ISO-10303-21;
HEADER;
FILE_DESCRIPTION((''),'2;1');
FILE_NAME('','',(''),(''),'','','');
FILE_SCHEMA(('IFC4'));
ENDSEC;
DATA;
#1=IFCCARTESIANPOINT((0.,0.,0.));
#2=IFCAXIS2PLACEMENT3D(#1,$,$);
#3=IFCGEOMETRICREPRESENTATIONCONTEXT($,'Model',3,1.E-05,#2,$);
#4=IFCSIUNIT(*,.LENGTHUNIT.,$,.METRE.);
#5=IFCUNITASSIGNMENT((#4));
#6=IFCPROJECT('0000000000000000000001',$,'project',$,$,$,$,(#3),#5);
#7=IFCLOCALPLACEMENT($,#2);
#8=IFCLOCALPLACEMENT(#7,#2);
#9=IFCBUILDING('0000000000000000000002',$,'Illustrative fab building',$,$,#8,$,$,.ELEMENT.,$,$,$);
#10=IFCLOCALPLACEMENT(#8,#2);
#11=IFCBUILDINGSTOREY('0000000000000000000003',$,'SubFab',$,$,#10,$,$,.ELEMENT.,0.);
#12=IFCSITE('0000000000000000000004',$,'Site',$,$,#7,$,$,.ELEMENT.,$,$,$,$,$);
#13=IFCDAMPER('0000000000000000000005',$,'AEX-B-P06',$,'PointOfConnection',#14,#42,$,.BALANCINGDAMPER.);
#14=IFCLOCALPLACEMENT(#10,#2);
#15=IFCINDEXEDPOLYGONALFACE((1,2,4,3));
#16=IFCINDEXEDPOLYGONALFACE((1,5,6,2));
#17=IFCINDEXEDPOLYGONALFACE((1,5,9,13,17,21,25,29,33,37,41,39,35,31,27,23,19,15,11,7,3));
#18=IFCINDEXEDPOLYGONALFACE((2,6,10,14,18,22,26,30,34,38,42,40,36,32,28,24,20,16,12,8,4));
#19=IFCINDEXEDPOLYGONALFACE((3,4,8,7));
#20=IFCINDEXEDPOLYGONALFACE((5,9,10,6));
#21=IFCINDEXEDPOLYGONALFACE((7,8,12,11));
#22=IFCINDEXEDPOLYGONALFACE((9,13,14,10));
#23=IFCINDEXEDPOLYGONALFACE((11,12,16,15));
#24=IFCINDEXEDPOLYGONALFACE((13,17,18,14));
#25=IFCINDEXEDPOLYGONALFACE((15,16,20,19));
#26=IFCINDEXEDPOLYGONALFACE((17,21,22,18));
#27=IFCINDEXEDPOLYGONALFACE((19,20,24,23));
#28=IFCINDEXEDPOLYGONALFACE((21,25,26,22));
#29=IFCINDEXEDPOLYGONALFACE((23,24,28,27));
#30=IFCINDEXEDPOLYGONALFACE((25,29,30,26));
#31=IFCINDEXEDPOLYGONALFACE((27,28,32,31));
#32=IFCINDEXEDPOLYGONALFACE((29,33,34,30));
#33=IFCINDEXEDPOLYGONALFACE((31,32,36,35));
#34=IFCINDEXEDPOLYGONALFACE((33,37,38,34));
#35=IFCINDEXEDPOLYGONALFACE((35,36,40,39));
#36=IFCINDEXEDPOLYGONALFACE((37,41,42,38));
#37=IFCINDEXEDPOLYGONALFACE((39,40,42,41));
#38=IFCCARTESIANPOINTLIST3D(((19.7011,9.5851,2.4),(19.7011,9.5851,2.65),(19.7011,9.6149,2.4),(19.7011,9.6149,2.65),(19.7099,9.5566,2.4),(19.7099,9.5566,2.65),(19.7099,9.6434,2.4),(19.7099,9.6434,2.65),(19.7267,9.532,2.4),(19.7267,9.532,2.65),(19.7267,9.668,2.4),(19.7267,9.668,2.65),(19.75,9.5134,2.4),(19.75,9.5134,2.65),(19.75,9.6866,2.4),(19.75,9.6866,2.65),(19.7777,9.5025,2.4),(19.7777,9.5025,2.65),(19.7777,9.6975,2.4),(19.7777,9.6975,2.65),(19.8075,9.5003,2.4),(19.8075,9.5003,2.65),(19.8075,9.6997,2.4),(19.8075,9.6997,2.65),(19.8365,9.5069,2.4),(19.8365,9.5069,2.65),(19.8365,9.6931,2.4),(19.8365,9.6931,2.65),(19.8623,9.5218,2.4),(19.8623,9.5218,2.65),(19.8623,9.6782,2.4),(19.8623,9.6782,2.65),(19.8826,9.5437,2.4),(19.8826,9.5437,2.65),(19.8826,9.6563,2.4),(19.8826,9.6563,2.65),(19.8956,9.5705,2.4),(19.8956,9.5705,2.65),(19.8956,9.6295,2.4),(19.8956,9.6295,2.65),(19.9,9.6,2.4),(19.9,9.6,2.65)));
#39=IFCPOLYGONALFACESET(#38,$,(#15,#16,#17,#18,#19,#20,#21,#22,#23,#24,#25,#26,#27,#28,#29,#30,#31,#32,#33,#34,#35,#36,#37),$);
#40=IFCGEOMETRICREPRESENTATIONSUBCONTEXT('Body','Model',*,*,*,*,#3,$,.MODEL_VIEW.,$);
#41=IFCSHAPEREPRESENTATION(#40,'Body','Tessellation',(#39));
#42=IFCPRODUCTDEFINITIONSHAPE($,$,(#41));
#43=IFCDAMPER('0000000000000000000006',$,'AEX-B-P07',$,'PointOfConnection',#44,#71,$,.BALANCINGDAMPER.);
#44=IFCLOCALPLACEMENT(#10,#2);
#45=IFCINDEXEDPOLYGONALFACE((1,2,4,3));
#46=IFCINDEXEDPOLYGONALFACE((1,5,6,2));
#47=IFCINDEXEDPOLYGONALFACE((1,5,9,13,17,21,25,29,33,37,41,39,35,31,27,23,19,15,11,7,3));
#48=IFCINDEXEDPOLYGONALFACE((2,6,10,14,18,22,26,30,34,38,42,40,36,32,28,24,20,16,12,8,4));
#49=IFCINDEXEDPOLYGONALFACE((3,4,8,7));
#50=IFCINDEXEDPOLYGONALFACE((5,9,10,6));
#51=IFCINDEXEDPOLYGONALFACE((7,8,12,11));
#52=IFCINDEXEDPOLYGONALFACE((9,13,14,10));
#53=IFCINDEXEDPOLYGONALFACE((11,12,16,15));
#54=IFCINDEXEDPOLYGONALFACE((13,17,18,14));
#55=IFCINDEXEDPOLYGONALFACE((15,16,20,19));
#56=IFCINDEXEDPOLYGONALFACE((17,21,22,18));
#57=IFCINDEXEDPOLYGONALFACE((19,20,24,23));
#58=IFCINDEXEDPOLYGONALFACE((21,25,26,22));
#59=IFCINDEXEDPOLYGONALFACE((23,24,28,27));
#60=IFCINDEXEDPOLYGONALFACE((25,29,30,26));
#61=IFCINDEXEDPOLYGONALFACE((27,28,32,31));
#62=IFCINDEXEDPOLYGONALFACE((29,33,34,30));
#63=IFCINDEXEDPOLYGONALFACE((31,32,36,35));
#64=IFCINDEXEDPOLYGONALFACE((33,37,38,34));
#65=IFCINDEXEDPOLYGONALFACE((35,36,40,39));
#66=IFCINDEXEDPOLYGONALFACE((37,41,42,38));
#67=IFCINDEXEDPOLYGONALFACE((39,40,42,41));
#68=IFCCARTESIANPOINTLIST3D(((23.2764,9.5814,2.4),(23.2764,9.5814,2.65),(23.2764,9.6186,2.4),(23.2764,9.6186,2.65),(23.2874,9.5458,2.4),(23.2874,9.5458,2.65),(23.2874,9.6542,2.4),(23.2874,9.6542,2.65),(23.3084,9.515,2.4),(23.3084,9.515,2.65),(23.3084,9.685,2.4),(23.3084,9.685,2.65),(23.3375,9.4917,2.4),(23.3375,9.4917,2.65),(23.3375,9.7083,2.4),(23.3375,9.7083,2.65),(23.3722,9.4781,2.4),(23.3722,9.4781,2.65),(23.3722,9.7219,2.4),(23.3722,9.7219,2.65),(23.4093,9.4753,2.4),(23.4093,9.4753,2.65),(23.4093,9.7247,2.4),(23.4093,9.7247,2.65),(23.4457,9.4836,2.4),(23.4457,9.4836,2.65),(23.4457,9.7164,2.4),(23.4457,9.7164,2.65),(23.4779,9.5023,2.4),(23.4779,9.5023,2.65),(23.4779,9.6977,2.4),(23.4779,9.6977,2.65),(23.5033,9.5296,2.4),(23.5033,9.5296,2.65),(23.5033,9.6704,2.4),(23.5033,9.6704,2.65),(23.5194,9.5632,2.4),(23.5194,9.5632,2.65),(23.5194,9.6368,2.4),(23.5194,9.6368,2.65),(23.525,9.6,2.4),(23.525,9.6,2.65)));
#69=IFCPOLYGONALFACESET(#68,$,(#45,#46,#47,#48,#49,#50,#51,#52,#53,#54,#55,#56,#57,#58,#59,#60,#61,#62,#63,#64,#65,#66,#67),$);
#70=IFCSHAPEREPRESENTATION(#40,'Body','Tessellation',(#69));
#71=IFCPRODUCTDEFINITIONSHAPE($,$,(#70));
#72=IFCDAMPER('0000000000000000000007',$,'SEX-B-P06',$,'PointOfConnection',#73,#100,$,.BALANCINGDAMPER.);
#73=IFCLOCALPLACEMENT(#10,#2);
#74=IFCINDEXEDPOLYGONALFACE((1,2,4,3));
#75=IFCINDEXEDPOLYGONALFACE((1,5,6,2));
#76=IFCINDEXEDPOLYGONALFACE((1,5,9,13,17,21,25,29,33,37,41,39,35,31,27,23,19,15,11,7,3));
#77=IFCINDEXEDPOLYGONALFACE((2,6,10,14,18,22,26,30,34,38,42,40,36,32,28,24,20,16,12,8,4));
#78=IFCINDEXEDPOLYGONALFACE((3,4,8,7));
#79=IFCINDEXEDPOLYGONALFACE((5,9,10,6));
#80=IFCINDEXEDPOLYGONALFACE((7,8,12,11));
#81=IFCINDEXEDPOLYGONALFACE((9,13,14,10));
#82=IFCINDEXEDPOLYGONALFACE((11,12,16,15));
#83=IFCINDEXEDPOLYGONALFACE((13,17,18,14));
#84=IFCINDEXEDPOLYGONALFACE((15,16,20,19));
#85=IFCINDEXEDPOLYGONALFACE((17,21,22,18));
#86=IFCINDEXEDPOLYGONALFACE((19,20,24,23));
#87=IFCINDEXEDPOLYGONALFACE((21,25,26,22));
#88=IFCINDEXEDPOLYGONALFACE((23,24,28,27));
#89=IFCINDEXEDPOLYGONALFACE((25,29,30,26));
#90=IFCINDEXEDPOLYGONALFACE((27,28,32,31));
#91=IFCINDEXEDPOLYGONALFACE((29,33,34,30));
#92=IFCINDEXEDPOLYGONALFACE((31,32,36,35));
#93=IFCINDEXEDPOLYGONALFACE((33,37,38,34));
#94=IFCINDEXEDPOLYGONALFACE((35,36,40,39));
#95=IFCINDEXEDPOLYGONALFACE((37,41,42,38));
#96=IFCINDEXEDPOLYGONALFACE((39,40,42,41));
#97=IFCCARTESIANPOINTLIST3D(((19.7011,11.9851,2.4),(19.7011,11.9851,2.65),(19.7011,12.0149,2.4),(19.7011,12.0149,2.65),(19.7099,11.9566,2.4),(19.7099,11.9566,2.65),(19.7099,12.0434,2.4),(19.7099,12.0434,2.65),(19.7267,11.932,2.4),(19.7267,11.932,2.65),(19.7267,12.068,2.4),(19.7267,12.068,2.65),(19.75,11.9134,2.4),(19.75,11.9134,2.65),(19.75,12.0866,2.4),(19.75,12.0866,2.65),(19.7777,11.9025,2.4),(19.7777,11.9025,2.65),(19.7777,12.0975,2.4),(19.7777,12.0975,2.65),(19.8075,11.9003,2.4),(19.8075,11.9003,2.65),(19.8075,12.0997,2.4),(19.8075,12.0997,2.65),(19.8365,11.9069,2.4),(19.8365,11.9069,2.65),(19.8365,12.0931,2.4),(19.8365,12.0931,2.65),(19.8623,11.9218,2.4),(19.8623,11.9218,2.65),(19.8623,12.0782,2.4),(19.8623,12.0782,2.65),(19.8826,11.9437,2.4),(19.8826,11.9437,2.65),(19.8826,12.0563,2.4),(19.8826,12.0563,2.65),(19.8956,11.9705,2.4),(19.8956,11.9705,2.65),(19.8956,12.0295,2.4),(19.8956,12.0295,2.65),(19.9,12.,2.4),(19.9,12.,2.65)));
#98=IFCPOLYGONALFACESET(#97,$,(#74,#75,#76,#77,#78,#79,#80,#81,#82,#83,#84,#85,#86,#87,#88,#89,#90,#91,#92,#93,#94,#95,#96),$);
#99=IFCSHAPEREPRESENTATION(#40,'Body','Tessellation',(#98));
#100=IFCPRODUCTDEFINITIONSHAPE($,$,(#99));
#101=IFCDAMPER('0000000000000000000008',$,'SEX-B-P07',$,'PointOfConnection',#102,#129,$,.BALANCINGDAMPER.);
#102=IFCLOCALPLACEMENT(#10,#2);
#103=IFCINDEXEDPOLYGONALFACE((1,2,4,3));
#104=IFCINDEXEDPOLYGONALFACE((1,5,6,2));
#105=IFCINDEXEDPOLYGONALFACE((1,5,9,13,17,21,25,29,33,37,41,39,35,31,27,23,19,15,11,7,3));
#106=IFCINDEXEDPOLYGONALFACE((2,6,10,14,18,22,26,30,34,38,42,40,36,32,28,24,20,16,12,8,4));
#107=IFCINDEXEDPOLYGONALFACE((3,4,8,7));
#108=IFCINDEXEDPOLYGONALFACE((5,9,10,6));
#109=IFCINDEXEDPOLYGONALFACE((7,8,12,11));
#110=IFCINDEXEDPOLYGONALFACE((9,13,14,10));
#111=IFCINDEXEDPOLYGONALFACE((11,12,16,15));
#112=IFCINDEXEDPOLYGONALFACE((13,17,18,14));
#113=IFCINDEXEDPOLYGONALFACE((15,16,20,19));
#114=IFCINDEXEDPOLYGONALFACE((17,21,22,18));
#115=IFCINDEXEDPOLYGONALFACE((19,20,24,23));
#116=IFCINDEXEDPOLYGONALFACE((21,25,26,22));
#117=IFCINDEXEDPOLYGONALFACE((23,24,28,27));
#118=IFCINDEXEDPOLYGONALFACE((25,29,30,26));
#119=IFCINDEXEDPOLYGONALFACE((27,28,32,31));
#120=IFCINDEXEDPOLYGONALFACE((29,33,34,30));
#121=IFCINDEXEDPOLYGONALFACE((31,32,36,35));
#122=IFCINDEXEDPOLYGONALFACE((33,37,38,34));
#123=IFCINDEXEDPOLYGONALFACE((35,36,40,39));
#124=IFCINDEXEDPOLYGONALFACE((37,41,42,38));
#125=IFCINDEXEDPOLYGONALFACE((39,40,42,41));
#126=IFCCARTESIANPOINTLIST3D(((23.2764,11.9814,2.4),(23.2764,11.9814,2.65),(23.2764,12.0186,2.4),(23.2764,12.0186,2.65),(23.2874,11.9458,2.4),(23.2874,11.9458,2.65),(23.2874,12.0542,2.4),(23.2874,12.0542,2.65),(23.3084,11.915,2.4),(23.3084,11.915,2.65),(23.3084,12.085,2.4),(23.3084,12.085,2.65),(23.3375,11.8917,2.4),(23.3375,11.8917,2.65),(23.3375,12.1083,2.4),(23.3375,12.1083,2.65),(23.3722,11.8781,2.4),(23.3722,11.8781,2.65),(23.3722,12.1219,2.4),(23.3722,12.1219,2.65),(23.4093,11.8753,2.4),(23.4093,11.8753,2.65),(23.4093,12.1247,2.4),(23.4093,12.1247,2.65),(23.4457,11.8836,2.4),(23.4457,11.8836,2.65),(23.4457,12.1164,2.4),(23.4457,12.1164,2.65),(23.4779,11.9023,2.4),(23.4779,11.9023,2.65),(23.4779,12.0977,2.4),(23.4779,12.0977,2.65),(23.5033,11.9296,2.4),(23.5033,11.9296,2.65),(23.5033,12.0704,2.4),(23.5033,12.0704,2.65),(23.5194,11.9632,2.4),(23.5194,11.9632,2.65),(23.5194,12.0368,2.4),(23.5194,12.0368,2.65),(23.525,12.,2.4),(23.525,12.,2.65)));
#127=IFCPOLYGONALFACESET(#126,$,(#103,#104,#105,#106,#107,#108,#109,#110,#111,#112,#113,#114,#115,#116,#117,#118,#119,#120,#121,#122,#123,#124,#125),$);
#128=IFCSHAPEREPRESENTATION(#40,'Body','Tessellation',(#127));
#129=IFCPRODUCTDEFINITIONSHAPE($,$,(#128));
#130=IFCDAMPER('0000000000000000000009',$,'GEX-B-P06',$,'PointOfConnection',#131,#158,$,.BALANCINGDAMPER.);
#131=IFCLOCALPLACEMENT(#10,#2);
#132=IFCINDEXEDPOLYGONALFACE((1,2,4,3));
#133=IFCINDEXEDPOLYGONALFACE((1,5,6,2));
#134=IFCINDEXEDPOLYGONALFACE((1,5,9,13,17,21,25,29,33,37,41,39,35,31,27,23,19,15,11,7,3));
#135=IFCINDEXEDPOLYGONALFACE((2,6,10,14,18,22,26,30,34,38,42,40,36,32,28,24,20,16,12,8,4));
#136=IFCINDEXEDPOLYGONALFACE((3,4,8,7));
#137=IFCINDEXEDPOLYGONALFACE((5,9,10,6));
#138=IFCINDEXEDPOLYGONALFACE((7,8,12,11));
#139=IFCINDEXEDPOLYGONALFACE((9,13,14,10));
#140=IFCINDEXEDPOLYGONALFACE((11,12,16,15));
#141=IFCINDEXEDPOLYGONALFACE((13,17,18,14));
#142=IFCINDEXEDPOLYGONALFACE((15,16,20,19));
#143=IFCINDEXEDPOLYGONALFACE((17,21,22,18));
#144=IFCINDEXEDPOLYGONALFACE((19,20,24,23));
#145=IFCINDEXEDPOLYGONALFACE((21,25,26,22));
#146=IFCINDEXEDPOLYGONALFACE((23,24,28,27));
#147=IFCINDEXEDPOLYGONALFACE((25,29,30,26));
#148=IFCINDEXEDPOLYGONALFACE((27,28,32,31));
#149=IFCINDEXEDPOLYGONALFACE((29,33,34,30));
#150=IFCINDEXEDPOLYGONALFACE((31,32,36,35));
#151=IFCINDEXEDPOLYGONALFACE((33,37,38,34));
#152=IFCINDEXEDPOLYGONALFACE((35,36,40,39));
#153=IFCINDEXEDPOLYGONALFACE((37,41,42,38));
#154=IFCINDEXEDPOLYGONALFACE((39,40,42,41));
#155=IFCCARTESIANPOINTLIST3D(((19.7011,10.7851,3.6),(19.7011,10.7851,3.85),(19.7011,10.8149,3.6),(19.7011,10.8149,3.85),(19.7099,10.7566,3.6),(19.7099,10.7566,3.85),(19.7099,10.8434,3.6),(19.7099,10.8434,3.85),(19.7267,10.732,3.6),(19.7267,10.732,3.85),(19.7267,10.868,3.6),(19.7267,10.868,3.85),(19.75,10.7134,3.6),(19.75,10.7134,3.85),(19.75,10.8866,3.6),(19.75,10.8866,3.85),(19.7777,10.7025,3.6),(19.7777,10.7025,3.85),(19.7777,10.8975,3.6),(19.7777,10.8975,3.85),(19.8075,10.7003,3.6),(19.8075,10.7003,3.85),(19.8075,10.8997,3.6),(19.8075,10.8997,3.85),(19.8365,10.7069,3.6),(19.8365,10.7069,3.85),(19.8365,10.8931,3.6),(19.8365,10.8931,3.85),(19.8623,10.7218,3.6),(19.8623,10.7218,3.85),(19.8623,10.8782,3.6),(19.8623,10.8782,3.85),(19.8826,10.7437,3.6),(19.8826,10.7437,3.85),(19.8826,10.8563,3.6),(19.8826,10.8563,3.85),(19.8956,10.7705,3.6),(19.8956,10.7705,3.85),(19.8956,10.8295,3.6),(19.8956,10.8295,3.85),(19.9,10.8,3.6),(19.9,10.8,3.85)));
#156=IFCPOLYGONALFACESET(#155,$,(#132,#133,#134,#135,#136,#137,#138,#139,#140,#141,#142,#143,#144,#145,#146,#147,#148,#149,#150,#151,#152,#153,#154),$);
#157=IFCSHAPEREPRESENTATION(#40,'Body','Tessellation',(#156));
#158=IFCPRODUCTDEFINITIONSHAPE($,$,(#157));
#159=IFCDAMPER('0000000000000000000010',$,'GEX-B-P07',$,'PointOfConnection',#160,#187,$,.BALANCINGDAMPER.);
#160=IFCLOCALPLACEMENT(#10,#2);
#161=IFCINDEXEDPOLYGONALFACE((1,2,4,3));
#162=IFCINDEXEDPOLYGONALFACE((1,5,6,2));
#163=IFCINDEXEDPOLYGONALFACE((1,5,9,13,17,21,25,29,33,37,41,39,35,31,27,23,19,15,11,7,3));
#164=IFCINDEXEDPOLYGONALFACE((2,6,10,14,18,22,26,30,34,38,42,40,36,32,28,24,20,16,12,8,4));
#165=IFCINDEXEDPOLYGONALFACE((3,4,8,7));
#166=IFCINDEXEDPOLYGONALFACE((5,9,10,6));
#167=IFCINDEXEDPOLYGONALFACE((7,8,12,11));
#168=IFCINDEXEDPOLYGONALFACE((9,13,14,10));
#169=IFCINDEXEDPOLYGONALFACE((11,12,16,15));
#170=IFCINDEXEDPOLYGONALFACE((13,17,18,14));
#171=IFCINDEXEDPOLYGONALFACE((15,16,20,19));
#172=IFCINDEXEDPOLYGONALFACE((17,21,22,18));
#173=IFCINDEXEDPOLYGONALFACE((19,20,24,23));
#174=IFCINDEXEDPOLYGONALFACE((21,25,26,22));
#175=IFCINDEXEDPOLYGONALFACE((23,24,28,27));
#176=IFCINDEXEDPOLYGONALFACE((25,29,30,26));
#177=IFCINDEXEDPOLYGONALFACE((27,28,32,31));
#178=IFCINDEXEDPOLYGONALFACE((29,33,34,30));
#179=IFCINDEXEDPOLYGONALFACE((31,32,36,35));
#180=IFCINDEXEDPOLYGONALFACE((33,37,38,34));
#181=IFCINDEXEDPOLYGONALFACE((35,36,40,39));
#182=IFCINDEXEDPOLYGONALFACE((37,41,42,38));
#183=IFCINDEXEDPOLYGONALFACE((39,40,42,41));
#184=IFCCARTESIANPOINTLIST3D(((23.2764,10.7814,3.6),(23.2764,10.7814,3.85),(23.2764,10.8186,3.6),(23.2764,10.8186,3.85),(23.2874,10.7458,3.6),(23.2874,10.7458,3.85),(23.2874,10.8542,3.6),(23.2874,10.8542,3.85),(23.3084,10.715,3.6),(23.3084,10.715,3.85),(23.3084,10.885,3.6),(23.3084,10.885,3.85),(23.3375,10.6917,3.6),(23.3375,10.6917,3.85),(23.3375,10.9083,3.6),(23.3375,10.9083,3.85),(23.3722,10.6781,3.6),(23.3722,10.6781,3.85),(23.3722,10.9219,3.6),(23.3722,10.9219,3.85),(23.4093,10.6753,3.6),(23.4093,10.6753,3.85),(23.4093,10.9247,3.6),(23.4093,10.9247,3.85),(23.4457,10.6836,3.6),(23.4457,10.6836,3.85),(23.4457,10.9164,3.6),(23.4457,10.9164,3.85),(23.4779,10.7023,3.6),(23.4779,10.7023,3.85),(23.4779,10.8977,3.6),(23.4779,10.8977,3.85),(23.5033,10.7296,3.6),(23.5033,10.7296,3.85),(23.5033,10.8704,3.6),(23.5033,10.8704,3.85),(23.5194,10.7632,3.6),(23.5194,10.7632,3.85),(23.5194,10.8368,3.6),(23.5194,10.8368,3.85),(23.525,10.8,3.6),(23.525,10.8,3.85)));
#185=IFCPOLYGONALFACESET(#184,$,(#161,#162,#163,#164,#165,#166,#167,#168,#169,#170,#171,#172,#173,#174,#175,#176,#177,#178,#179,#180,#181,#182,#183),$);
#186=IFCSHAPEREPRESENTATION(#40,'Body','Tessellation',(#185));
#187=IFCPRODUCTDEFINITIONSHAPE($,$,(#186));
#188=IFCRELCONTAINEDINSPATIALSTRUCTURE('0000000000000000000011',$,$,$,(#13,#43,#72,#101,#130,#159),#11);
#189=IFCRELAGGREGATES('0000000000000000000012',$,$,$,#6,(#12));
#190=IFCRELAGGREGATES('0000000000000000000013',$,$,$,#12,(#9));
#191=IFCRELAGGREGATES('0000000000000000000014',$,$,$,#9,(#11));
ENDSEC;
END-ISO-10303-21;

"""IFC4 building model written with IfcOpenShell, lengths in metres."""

from ifc_helpers import new_model, entity, si_unit, frame, origin, place, context, subcontext, project, spatial, element, save


model = new_model("IFC4")

# Units and contexts
model_context = context("Model", 3, precision=1e-05, world=origin())
body_context = subcontext(model_context, "Body", "Model", "MODEL_VIEW")
ifc_project = project(units=[si_unit("LENGTHUNIT", "METRE")], contexts=[model_context])

# Site, building, storey
site_placement = place(None, origin())
site = spatial("IfcSite", under=ifc_project, at=site_placement, Name="Site", CompositionType="ELEMENT")
building_placement = place(site_placement, origin())
building = spatial("IfcBuilding", under=site, at=building_placement, Name="Illustrative fab building", CompositionType="ELEMENT")
storey_placement = place(building_placement, origin())
storey = spatial("IfcBuildingStorey", under=building, at=storey_placement, Name="SubFab", CompositionType="ELEMENT", Elevation=0.0)

# Dampers
damper_1_placement = place(storey_placement, frame((19.8, 9.6, 2.4)))
element("IfcDamper", 1, at=damper_1_placement, inside=storey, Name="AEX-B-P06", ObjectType="PointOfConnection", PredefinedType="BALANCINGDAMPER", context=body_context, shape_type="AdvancedSweptSolid", body=[
    entity("IfcSweptDiskSolid", entity("IfcPolyline", [entity("IfcCartesianPoint", [0.0, 0.0, 0.0]), entity("IfcCartesianPoint", [0.0, 0.0, 0.25])]), 0.1),
])
damper_2_placement = place(storey_placement, frame((23.4, 9.6, 2.4)))
element("IfcDamper", 2, at=damper_2_placement, inside=storey, Name="AEX-B-P07", ObjectType="PointOfConnection", PredefinedType="BALANCINGDAMPER", context=body_context, shape_type="AdvancedSweptSolid", body=[
    entity("IfcSweptDiskSolid", entity("IfcPolyline", [entity("IfcCartesianPoint", [0.0, 0.0, 0.0]), entity("IfcCartesianPoint", [0.0, 0.0, 0.25])]), 0.125),
])
damper_3_placement = place(storey_placement, frame((19.8, 12.0, 2.4)))
element("IfcDamper", 3, at=damper_3_placement, inside=storey, Name="SEX-B-P06", ObjectType="PointOfConnection", PredefinedType="BALANCINGDAMPER", context=body_context, shape_type="AdvancedSweptSolid", body=[
    entity("IfcSweptDiskSolid", entity("IfcPolyline", [entity("IfcCartesianPoint", [0.0, 0.0, 0.0]), entity("IfcCartesianPoint", [0.0, 0.0, 0.25])]), 0.1),
])
damper_4_placement = place(storey_placement, frame((23.4, 12.0, 2.4)))
element("IfcDamper", 4, at=damper_4_placement, inside=storey, Name="SEX-B-P07", ObjectType="PointOfConnection", PredefinedType="BALANCINGDAMPER", context=body_context, shape_type="AdvancedSweptSolid", body=[
    entity("IfcSweptDiskSolid", entity("IfcPolyline", [entity("IfcCartesianPoint", [0.0, 0.0, 0.0]), entity("IfcCartesianPoint", [0.0, 0.0, 0.25])]), 0.125),
])
damper_5_placement = place(storey_placement, frame((19.8, 10.8, 3.6)))
element("IfcDamper", 5, at=damper_5_placement, inside=storey, Name="GEX-B-P06", ObjectType="PointOfConnection", PredefinedType="BALANCINGDAMPER", context=body_context, shape_type="AdvancedSweptSolid", body=[
    entity("IfcSweptDiskSolid", entity("IfcPolyline", [entity("IfcCartesianPoint", [0.0, 0.0, 0.0]), entity("IfcCartesianPoint", [0.0, 0.0, 0.25])]), 0.1),
])
damper_6_placement = place(storey_placement, frame((23.4, 10.8, 3.6)))
element("IfcDamper", 6, at=damper_6_placement, inside=storey, Name="GEX-B-P07", ObjectType="PointOfConnection", PredefinedType="BALANCINGDAMPER", context=body_context, shape_type="AdvancedSweptSolid", body=[
    entity("IfcSweptDiskSolid", entity("IfcPolyline", [entity("IfcCartesianPoint", [0.0, 0.0, 0.0]), entity("IfcCartesianPoint", [0.0, 0.0, 0.25])]), 0.125),
])

save(model, "model.ifc")
